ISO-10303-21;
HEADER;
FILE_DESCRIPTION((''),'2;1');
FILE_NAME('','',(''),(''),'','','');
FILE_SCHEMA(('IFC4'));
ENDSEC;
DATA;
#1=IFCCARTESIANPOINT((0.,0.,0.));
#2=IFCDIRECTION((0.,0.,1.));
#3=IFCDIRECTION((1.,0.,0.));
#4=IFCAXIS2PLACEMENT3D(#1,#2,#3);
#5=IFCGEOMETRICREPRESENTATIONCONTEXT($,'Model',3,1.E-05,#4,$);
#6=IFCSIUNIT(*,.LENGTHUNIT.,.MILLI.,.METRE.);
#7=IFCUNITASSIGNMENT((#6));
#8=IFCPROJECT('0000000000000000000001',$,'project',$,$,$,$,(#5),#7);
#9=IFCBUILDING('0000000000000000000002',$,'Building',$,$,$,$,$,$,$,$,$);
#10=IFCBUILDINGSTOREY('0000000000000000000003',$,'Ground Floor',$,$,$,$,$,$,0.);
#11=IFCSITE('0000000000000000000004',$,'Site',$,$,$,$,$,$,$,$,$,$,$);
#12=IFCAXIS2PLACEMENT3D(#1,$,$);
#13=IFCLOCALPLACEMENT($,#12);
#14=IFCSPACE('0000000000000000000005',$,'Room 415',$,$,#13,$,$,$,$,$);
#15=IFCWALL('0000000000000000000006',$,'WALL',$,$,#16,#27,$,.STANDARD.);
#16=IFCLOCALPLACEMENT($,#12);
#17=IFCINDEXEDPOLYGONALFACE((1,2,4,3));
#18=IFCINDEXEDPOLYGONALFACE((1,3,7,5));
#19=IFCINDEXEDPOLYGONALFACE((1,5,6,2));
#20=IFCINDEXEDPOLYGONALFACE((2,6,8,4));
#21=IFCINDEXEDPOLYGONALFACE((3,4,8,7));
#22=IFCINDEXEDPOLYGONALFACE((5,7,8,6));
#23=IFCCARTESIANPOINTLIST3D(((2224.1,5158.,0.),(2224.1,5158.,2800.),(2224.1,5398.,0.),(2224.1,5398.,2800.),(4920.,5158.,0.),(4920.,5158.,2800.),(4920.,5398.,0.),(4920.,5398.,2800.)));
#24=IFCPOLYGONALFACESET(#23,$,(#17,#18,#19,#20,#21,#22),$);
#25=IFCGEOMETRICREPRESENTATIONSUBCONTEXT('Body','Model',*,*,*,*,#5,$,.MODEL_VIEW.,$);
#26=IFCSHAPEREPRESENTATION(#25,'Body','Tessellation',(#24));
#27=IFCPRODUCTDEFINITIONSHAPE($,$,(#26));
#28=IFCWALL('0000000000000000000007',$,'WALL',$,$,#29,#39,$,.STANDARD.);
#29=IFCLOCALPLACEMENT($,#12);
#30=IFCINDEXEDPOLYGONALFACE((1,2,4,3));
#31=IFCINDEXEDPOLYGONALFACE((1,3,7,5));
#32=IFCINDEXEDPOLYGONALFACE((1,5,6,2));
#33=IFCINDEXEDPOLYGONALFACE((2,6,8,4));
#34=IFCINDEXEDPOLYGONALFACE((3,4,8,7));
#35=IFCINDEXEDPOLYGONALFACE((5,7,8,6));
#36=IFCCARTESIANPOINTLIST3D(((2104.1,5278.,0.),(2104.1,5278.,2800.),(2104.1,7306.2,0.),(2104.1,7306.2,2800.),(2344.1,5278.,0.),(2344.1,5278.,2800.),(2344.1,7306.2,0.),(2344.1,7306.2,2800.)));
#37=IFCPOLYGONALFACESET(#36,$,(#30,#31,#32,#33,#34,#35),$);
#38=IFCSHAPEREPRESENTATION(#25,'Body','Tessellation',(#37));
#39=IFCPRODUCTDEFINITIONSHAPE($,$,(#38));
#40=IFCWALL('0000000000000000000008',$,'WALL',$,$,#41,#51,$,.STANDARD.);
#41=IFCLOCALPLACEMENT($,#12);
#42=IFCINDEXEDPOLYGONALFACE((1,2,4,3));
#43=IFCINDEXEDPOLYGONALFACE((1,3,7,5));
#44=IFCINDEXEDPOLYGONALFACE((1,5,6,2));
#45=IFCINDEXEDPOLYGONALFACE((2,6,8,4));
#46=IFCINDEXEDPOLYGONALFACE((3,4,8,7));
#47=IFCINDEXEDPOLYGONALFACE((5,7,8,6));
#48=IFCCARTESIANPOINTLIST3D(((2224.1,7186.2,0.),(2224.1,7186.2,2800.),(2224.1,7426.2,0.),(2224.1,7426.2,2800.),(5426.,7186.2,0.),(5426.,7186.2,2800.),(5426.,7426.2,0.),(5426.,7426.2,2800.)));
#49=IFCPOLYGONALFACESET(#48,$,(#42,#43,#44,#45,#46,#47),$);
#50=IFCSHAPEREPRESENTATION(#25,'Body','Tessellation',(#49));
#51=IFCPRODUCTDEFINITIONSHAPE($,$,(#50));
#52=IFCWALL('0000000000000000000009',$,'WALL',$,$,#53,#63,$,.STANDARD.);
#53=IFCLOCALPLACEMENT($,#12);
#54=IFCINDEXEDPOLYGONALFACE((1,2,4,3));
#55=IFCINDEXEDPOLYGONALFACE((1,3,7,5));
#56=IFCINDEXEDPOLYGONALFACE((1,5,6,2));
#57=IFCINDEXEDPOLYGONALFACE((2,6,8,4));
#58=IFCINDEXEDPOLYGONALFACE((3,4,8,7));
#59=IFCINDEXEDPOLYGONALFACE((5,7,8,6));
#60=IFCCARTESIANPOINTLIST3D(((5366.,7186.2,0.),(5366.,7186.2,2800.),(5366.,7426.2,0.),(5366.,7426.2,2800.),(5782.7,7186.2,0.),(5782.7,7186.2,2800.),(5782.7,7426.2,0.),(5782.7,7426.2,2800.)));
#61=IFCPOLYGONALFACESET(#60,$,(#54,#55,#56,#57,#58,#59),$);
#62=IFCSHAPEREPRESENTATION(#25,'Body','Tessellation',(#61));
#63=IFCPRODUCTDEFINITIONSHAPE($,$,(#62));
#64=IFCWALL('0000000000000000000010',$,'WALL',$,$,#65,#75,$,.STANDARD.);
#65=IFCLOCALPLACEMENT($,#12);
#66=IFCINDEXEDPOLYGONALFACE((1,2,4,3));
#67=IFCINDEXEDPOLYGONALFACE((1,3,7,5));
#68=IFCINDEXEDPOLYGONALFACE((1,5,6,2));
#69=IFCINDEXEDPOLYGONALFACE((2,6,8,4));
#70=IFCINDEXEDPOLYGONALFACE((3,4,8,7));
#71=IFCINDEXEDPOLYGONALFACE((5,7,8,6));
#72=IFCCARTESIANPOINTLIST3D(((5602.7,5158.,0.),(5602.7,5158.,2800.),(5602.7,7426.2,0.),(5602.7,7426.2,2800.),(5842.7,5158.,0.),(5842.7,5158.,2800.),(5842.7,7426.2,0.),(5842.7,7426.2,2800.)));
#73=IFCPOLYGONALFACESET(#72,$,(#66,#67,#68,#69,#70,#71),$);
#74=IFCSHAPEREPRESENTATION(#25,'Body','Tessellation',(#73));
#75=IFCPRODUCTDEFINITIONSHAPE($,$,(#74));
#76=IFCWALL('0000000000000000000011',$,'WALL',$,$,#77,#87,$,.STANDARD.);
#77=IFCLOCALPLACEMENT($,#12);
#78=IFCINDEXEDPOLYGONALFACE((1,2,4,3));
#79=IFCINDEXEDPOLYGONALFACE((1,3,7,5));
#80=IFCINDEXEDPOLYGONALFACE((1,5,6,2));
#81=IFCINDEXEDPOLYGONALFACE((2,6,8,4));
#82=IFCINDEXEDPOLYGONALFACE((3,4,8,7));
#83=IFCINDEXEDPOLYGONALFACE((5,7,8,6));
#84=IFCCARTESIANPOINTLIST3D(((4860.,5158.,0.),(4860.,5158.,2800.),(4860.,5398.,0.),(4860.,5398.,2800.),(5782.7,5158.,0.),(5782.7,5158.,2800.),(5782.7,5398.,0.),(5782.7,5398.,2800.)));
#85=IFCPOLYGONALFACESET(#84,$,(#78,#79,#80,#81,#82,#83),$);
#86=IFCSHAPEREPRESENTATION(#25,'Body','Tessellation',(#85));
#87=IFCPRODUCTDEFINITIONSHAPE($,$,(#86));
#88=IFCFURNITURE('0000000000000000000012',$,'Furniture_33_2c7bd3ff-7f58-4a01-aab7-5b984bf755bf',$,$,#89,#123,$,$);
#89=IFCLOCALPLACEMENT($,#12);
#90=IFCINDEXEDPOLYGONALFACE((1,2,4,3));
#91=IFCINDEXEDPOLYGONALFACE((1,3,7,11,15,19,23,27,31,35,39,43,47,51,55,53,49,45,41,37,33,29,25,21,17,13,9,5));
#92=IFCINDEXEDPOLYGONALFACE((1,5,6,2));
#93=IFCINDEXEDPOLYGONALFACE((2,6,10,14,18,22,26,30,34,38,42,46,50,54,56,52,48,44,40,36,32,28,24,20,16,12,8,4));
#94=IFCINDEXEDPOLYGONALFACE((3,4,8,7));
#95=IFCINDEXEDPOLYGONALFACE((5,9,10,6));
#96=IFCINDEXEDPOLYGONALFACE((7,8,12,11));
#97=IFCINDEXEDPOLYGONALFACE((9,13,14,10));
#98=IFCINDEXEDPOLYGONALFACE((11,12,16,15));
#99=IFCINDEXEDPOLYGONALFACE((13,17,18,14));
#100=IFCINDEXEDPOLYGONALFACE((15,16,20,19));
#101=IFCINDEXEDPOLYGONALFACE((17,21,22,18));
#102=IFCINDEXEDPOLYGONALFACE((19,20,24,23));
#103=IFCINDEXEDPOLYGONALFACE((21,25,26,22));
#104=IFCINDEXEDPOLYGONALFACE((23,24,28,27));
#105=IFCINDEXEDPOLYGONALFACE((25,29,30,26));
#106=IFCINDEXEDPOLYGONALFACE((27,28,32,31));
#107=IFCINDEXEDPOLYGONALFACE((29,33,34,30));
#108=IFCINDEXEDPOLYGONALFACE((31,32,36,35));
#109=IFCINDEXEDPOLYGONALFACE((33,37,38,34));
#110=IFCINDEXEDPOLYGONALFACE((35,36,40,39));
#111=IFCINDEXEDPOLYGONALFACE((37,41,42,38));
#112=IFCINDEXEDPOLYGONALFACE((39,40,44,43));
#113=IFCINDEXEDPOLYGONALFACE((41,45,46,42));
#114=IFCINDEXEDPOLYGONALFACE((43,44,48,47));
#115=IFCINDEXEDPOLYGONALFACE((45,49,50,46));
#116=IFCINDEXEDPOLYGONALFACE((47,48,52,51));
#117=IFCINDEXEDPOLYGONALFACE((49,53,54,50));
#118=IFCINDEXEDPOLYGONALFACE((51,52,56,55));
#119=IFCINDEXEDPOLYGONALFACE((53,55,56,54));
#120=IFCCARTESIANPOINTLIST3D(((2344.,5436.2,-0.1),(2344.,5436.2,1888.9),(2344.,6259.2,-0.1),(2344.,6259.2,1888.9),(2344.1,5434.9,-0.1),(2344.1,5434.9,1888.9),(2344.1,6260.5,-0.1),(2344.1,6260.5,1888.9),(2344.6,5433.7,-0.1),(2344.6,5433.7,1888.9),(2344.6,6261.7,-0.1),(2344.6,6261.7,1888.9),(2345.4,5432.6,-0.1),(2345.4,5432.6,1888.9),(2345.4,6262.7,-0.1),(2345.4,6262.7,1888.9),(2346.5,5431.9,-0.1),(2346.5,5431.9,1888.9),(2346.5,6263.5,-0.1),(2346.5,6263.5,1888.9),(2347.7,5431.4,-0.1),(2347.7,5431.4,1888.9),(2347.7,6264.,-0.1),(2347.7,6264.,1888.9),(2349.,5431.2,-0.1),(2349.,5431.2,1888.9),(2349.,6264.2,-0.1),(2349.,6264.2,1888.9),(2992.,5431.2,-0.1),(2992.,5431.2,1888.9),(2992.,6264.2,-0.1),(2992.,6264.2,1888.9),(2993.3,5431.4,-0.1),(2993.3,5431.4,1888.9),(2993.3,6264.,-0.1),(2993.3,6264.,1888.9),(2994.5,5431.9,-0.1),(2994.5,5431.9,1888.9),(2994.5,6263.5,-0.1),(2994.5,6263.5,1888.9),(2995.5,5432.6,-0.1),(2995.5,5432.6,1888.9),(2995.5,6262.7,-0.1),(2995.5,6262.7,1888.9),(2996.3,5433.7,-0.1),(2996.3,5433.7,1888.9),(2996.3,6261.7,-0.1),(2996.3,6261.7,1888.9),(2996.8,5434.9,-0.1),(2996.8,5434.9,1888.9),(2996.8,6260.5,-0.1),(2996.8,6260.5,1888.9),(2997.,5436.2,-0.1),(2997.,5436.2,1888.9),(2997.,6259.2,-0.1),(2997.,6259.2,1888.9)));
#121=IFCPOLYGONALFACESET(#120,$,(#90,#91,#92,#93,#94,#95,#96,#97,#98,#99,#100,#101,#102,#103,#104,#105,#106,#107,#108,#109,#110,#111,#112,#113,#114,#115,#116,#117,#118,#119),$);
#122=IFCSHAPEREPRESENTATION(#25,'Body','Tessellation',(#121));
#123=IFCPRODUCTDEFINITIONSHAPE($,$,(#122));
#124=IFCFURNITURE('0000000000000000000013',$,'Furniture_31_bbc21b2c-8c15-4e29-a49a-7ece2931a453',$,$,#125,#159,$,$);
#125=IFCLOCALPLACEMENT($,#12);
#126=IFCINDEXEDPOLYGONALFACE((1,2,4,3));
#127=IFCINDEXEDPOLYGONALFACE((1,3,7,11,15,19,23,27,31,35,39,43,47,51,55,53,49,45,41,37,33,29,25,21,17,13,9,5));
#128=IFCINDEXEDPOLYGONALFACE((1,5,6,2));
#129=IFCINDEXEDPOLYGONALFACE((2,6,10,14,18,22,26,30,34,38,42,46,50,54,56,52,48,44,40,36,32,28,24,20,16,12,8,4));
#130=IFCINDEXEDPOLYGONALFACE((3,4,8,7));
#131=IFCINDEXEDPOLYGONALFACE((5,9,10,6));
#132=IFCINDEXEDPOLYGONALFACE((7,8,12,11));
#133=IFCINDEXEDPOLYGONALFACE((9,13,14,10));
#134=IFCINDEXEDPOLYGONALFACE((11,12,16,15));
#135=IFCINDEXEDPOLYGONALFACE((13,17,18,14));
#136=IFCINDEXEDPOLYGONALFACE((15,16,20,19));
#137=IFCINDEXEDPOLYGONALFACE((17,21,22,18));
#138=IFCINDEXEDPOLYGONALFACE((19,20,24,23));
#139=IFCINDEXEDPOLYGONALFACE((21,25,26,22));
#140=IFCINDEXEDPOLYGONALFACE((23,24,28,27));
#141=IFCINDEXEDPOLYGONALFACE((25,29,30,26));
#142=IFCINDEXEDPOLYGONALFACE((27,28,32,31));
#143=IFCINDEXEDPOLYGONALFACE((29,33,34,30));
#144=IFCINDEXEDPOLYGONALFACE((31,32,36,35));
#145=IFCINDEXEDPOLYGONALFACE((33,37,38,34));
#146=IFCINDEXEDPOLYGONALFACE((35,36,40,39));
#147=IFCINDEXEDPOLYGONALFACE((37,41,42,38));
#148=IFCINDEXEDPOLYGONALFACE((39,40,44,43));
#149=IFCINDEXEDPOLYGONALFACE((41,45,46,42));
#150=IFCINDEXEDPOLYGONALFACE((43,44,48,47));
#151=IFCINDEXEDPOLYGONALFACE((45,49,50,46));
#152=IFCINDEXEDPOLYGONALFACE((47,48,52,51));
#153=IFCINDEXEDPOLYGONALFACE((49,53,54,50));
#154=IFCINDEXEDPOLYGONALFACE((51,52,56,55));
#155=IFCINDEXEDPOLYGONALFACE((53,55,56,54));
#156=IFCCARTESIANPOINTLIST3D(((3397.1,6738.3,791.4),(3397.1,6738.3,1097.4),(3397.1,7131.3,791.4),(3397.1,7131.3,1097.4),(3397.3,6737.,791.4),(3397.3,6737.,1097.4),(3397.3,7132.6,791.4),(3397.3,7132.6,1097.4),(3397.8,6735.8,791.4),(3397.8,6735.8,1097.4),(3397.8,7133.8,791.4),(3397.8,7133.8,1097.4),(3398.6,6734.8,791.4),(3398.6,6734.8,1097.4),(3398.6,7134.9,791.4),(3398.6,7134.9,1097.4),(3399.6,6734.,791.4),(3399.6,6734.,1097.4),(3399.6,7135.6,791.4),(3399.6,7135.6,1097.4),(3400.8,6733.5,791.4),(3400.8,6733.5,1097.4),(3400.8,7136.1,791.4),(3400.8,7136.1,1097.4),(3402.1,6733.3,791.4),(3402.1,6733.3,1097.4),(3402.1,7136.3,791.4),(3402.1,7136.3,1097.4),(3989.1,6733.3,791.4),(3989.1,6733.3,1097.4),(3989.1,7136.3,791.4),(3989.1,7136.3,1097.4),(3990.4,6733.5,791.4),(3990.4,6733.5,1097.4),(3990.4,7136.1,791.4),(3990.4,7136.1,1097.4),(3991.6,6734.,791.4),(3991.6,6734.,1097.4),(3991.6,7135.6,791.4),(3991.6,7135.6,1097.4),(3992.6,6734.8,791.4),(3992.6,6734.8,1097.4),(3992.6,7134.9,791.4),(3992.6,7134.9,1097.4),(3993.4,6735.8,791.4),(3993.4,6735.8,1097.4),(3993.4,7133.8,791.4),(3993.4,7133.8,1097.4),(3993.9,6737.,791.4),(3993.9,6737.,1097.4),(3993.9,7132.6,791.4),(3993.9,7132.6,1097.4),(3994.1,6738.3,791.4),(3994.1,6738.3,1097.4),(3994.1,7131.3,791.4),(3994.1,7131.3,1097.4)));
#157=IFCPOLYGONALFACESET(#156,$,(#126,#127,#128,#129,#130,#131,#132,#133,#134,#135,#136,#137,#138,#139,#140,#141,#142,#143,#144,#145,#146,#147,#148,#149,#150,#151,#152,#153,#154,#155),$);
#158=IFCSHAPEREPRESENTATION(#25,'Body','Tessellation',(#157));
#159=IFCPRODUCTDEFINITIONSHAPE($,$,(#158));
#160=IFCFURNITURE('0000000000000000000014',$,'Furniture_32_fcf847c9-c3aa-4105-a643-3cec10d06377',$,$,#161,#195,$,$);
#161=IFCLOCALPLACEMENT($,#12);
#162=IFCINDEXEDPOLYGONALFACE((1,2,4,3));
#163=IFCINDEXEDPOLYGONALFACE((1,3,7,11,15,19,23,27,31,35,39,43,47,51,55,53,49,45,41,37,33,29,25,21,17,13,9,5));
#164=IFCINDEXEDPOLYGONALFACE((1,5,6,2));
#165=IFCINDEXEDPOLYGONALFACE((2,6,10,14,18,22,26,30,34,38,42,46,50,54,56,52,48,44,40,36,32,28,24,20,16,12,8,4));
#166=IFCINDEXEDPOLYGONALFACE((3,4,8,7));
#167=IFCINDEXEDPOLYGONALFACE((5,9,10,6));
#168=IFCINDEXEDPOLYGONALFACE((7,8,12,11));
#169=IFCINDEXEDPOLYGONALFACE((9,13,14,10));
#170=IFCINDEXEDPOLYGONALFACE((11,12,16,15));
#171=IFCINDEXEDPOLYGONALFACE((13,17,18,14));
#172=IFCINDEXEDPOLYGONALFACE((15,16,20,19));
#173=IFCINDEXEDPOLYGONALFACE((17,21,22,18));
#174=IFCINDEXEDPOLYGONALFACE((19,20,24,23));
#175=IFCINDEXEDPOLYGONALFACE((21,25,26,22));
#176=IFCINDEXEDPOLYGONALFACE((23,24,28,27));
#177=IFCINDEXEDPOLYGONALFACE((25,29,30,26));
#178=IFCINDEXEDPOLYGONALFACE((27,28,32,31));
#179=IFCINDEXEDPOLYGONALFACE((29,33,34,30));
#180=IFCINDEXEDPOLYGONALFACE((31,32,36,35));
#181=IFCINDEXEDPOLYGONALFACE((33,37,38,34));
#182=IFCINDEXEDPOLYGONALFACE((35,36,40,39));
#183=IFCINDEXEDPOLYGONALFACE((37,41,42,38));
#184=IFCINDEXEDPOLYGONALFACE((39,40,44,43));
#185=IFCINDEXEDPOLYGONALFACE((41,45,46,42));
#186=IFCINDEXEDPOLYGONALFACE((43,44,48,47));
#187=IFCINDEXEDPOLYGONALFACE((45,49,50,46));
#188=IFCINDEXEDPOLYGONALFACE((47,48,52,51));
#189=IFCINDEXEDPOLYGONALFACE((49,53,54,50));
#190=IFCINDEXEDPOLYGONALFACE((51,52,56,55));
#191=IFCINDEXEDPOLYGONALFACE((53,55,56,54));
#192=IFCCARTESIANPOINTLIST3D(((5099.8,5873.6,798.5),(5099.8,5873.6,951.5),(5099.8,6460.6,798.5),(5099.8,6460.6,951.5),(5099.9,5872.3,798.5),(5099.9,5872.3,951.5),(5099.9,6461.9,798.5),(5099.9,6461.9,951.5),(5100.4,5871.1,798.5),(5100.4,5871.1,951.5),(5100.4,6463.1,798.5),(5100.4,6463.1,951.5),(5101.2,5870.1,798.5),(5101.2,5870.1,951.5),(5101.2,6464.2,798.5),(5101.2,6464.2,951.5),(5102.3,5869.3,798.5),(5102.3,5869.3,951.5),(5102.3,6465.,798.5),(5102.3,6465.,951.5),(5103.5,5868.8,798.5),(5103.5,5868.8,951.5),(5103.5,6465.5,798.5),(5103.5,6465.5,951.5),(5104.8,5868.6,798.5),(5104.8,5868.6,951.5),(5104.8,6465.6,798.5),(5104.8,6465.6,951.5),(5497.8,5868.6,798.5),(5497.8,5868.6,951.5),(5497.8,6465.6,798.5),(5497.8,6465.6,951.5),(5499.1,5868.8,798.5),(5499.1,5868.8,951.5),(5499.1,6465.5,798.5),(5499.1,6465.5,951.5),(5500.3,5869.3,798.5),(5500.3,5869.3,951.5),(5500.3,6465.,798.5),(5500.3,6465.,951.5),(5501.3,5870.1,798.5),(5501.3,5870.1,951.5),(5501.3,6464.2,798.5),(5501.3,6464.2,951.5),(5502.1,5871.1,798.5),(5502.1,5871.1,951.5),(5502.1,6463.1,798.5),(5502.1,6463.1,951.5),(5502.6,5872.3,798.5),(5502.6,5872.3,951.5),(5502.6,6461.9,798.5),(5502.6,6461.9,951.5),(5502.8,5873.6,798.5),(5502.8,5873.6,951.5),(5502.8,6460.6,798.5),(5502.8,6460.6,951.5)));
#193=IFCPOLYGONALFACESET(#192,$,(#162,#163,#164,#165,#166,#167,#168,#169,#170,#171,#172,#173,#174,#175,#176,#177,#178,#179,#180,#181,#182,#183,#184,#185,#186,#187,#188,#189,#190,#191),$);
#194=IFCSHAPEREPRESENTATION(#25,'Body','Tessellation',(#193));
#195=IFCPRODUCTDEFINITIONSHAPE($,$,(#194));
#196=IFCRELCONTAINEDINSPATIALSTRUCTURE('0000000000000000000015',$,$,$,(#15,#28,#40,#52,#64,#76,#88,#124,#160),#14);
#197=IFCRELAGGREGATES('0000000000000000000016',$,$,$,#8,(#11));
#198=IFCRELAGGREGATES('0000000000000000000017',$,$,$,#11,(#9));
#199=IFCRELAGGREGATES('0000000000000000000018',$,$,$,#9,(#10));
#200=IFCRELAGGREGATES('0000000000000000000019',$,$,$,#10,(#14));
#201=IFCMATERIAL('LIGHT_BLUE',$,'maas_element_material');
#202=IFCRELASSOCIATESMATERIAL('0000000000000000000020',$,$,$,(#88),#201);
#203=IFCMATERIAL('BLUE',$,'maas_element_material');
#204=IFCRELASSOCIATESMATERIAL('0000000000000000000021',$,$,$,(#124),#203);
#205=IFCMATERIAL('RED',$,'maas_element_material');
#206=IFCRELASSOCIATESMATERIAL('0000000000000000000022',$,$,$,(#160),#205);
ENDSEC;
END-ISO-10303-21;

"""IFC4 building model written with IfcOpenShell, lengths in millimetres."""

from ifc_helpers import new_model, si_unit, frame, origin, origin_with_axes, origin_2d, place, context, subcontext, project, spatial, rectangle, rounded_rectangle, extrude, material, element, save


model = new_model("IFC4")

# Units and contexts
model_context = context("Model", 3, precision=1e-05, world=origin_with_axes())
body_context = subcontext(model_context, "Body", "Model", "MODEL_VIEW")
ifc_project = project(units=[si_unit("LENGTHUNIT", "METRE", prefix="MILLI")], contexts=[model_context])

# Site, building, storey, space
site = spatial("IfcSite", under=ifc_project, Name="Site")
building = spatial("IfcBuilding", under=site, Name="Building")
storey = spatial("IfcBuildingStorey", under=building, Name="Ground Floor", Elevation=0.0)
space_placement = place(None, origin())
space = spatial("IfcSpace", under=storey, at=space_placement, Name="Room 415")

# Wall, opening
wall_1_placement = place(space_placement, frame((3572.0, 5278.0, 0.0), z_axis=(0.0, 0.0, 1.0), x_axis=(1.0, 0.0, 0.0)))
wall_1 = element("IfcWall", 1, at=wall_1_placement, inside=space, Name="WALL", PredefinedType="STANDARD", context=body_context, shape_type="SweptSolid", body=[
    extrude(rectangle(XDim=2695.9, YDim=240.0, at=origin_2d()), origin(), (0.0, 0.0, 1.0), 2800.0),
])
opening_1_placement = place(wall_1_placement, frame((-3572.0, -5278.0, 0.0), z_axis=(0.0, 0.0, 1.0), x_axis=(1.0, 0.0, 0.0)))
element("IfcOpeningElement", 2, at=opening_1_placement, cuts=wall_1, context=body_context, shape_type="SweptSolid", body=[
    extrude(rectangle(XDim=1825.6, YDim=240.0, at=origin_2d()), origin(), (0.0, 0.0, 1.0), 1200.0),
])

# Wall
wall_2_placement = place(space_placement, frame((2224.1, 6292.1, 0.0), z_axis=(0.0, 0.0, 1.0), x_axis=(1.0, 0.0, 0.0)))
element("IfcWall", 3, at=wall_2_placement, inside=space, Name="WALL", PredefinedType="STANDARD", context=body_context, shape_type="SweptSolid", body=[
    extrude(rectangle(XDim=240.0, YDim=2028.2, at=origin_2d()), origin(), (0.0, 0.0, 1.0), 2800.0),
])

# Wall, opening
wall_3_placement = place(space_placement, frame((3825.0, 7306.2, 0.0), z_axis=(0.0, 0.0, 1.0), x_axis=(1.0, 0.0, 0.0)))
wall_3 = element("IfcWall", 4, at=wall_3_placement, inside=space, Name="WALL", PredefinedType="STANDARD", context=body_context, shape_type="SweptSolid", body=[
    extrude(rectangle(XDim=3201.9, YDim=240.0, at=origin_2d()), origin(), (0.0, 0.0, 1.0), 2800.0),
])
opening_2_placement = place(wall_3_placement, frame((-3825.0, -7306.2, 0.0), z_axis=(0.0, 0.0, 1.0), x_axis=(1.0, 0.0, 0.0)))
element("IfcOpeningElement", 5, at=opening_2_placement, cuts=wall_3, context=body_context, shape_type="SweptSolid", body=[
    extrude(rectangle(XDim=2852.0, YDim=240.0, at=origin_2d()), origin(), (0.0, 0.0, 1.0), 1200.0),
])

# Walls
wall_4_placement = place(space_placement, frame((5574.3, 7306.2, 0.0), z_axis=(0.0, 0.0, 1.0), x_axis=(1.0, 0.0, 0.0)))
element("IfcWall", 6, at=wall_4_placement, inside=space, Name="WALL", PredefinedType="STANDARD", context=body_context, shape_type="SweptSolid", body=[
    extrude(rectangle(XDim=416.7, YDim=240.0, at=origin_2d()), origin(), (0.0, 0.0, 1.0), 2800.0),
])
wall_5_placement = place(space_placement, frame((5722.7, 6292.1, 0.0), z_axis=(0.0, 0.0, 1.0), x_axis=(1.0, 0.0, 0.0)))
element("IfcWall", 7, at=wall_5_placement, inside=space, Name="WALL", PredefinedType="STANDARD", context=body_context, shape_type="SweptSolid", body=[
    extrude(rectangle(XDim=240.0, YDim=2268.2, at=origin_2d()), origin(), (0.0, 0.0, 1.0), 2800.0),
])
wall_6_placement = place(space_placement, frame((5321.3, 5278.0, 0.0), z_axis=(0.0, 0.0, 1.0), x_axis=(1.0, 0.0, 0.0)))
element("IfcWall", 8, at=wall_6_placement, inside=space, Name="WALL", PredefinedType="STANDARD", context=body_context, shape_type="SweptSolid", body=[
    extrude(rectangle(XDim=922.7, YDim=240.0, at=origin_2d()), origin(), (0.0, 0.0, 1.0), 2800.0),
])

# Furniture
ifc_material_1 = material(Name="LIGHT_BLUE", Category="maas_element_material")
furniture_1_placement = place(space_placement, frame((2670.5, 5847.7, 944.4), z_axis=(0.0, 0.0, 1.0), x_axis=(0.0, 1.0, 0.0)))
element("IfcFurniture", 9, at=furniture_1_placement, inside=space, material=ifc_material_1, Name="Furniture_33_2c7bd3ff-7f58-4a01-aab7-5b984bf755bf", context=body_context, shape_type="SweptSolid", body=[
    extrude(rounded_rectangle(XDim=833.0, YDim=653.0, RoundingRadius=5.0), frame((0.0, 0.0, -944.5), z_axis=(0.0, 0.0, 1.0), x_axis=(1.0, 0.0, 0.0)), (0.0, 0.0, 1.0), 1889.0),
])
ifc_material_2 = material(Name="BLUE", Category="maas_element_material")
furniture_2_placement = place(space_placement, frame((3695.6, 6934.8, 944.4), z_axis=(0.0, 0.0, 1.0), x_axis=(1.0, 0.0, 0.0)))
element("IfcFurniture", 10, at=furniture_2_placement, inside=space, material=ifc_material_2, Name="Furniture_31_bbc21b2c-8c15-4e29-a49a-7ece2931a453", context=body_context, shape_type="SweptSolid", body=[
    extrude(rounded_rectangle(XDim=597.0, YDim=403.0, RoundingRadius=5.0), frame((0.0, 0.0, -153.0), z_axis=(0.0, 0.0, 1.0), x_axis=(1.0, 0.0, 0.0)), (0.0, 0.0, 1.0), 306.0),
])
ifc_material_3 = material(Name="RED", Category="maas_element_material")
furniture_3_placement = place(space_placement, frame((5301.3, 6167.1, 875.0), z_axis=(0.0, 0.0, 1.0), x_axis=(0.0, -1.0, 0.0)))
element("IfcFurniture", 11, at=furniture_3_placement, inside=space, material=ifc_material_3, Name="Furniture_32_fcf847c9-c3aa-4105-a643-3cec10d06377", context=body_context, shape_type="SweptSolid", body=[
    extrude(rounded_rectangle(XDim=597.0, YDim=403.0, RoundingRadius=5.0), frame((0.0, 0.0, -76.5), z_axis=(0.0, 0.0, 1.0), x_axis=(1.0, 0.0, 0.0)), (0.0, 0.0, 1.0), 153.0),
])

save(model, "model.ifc")
